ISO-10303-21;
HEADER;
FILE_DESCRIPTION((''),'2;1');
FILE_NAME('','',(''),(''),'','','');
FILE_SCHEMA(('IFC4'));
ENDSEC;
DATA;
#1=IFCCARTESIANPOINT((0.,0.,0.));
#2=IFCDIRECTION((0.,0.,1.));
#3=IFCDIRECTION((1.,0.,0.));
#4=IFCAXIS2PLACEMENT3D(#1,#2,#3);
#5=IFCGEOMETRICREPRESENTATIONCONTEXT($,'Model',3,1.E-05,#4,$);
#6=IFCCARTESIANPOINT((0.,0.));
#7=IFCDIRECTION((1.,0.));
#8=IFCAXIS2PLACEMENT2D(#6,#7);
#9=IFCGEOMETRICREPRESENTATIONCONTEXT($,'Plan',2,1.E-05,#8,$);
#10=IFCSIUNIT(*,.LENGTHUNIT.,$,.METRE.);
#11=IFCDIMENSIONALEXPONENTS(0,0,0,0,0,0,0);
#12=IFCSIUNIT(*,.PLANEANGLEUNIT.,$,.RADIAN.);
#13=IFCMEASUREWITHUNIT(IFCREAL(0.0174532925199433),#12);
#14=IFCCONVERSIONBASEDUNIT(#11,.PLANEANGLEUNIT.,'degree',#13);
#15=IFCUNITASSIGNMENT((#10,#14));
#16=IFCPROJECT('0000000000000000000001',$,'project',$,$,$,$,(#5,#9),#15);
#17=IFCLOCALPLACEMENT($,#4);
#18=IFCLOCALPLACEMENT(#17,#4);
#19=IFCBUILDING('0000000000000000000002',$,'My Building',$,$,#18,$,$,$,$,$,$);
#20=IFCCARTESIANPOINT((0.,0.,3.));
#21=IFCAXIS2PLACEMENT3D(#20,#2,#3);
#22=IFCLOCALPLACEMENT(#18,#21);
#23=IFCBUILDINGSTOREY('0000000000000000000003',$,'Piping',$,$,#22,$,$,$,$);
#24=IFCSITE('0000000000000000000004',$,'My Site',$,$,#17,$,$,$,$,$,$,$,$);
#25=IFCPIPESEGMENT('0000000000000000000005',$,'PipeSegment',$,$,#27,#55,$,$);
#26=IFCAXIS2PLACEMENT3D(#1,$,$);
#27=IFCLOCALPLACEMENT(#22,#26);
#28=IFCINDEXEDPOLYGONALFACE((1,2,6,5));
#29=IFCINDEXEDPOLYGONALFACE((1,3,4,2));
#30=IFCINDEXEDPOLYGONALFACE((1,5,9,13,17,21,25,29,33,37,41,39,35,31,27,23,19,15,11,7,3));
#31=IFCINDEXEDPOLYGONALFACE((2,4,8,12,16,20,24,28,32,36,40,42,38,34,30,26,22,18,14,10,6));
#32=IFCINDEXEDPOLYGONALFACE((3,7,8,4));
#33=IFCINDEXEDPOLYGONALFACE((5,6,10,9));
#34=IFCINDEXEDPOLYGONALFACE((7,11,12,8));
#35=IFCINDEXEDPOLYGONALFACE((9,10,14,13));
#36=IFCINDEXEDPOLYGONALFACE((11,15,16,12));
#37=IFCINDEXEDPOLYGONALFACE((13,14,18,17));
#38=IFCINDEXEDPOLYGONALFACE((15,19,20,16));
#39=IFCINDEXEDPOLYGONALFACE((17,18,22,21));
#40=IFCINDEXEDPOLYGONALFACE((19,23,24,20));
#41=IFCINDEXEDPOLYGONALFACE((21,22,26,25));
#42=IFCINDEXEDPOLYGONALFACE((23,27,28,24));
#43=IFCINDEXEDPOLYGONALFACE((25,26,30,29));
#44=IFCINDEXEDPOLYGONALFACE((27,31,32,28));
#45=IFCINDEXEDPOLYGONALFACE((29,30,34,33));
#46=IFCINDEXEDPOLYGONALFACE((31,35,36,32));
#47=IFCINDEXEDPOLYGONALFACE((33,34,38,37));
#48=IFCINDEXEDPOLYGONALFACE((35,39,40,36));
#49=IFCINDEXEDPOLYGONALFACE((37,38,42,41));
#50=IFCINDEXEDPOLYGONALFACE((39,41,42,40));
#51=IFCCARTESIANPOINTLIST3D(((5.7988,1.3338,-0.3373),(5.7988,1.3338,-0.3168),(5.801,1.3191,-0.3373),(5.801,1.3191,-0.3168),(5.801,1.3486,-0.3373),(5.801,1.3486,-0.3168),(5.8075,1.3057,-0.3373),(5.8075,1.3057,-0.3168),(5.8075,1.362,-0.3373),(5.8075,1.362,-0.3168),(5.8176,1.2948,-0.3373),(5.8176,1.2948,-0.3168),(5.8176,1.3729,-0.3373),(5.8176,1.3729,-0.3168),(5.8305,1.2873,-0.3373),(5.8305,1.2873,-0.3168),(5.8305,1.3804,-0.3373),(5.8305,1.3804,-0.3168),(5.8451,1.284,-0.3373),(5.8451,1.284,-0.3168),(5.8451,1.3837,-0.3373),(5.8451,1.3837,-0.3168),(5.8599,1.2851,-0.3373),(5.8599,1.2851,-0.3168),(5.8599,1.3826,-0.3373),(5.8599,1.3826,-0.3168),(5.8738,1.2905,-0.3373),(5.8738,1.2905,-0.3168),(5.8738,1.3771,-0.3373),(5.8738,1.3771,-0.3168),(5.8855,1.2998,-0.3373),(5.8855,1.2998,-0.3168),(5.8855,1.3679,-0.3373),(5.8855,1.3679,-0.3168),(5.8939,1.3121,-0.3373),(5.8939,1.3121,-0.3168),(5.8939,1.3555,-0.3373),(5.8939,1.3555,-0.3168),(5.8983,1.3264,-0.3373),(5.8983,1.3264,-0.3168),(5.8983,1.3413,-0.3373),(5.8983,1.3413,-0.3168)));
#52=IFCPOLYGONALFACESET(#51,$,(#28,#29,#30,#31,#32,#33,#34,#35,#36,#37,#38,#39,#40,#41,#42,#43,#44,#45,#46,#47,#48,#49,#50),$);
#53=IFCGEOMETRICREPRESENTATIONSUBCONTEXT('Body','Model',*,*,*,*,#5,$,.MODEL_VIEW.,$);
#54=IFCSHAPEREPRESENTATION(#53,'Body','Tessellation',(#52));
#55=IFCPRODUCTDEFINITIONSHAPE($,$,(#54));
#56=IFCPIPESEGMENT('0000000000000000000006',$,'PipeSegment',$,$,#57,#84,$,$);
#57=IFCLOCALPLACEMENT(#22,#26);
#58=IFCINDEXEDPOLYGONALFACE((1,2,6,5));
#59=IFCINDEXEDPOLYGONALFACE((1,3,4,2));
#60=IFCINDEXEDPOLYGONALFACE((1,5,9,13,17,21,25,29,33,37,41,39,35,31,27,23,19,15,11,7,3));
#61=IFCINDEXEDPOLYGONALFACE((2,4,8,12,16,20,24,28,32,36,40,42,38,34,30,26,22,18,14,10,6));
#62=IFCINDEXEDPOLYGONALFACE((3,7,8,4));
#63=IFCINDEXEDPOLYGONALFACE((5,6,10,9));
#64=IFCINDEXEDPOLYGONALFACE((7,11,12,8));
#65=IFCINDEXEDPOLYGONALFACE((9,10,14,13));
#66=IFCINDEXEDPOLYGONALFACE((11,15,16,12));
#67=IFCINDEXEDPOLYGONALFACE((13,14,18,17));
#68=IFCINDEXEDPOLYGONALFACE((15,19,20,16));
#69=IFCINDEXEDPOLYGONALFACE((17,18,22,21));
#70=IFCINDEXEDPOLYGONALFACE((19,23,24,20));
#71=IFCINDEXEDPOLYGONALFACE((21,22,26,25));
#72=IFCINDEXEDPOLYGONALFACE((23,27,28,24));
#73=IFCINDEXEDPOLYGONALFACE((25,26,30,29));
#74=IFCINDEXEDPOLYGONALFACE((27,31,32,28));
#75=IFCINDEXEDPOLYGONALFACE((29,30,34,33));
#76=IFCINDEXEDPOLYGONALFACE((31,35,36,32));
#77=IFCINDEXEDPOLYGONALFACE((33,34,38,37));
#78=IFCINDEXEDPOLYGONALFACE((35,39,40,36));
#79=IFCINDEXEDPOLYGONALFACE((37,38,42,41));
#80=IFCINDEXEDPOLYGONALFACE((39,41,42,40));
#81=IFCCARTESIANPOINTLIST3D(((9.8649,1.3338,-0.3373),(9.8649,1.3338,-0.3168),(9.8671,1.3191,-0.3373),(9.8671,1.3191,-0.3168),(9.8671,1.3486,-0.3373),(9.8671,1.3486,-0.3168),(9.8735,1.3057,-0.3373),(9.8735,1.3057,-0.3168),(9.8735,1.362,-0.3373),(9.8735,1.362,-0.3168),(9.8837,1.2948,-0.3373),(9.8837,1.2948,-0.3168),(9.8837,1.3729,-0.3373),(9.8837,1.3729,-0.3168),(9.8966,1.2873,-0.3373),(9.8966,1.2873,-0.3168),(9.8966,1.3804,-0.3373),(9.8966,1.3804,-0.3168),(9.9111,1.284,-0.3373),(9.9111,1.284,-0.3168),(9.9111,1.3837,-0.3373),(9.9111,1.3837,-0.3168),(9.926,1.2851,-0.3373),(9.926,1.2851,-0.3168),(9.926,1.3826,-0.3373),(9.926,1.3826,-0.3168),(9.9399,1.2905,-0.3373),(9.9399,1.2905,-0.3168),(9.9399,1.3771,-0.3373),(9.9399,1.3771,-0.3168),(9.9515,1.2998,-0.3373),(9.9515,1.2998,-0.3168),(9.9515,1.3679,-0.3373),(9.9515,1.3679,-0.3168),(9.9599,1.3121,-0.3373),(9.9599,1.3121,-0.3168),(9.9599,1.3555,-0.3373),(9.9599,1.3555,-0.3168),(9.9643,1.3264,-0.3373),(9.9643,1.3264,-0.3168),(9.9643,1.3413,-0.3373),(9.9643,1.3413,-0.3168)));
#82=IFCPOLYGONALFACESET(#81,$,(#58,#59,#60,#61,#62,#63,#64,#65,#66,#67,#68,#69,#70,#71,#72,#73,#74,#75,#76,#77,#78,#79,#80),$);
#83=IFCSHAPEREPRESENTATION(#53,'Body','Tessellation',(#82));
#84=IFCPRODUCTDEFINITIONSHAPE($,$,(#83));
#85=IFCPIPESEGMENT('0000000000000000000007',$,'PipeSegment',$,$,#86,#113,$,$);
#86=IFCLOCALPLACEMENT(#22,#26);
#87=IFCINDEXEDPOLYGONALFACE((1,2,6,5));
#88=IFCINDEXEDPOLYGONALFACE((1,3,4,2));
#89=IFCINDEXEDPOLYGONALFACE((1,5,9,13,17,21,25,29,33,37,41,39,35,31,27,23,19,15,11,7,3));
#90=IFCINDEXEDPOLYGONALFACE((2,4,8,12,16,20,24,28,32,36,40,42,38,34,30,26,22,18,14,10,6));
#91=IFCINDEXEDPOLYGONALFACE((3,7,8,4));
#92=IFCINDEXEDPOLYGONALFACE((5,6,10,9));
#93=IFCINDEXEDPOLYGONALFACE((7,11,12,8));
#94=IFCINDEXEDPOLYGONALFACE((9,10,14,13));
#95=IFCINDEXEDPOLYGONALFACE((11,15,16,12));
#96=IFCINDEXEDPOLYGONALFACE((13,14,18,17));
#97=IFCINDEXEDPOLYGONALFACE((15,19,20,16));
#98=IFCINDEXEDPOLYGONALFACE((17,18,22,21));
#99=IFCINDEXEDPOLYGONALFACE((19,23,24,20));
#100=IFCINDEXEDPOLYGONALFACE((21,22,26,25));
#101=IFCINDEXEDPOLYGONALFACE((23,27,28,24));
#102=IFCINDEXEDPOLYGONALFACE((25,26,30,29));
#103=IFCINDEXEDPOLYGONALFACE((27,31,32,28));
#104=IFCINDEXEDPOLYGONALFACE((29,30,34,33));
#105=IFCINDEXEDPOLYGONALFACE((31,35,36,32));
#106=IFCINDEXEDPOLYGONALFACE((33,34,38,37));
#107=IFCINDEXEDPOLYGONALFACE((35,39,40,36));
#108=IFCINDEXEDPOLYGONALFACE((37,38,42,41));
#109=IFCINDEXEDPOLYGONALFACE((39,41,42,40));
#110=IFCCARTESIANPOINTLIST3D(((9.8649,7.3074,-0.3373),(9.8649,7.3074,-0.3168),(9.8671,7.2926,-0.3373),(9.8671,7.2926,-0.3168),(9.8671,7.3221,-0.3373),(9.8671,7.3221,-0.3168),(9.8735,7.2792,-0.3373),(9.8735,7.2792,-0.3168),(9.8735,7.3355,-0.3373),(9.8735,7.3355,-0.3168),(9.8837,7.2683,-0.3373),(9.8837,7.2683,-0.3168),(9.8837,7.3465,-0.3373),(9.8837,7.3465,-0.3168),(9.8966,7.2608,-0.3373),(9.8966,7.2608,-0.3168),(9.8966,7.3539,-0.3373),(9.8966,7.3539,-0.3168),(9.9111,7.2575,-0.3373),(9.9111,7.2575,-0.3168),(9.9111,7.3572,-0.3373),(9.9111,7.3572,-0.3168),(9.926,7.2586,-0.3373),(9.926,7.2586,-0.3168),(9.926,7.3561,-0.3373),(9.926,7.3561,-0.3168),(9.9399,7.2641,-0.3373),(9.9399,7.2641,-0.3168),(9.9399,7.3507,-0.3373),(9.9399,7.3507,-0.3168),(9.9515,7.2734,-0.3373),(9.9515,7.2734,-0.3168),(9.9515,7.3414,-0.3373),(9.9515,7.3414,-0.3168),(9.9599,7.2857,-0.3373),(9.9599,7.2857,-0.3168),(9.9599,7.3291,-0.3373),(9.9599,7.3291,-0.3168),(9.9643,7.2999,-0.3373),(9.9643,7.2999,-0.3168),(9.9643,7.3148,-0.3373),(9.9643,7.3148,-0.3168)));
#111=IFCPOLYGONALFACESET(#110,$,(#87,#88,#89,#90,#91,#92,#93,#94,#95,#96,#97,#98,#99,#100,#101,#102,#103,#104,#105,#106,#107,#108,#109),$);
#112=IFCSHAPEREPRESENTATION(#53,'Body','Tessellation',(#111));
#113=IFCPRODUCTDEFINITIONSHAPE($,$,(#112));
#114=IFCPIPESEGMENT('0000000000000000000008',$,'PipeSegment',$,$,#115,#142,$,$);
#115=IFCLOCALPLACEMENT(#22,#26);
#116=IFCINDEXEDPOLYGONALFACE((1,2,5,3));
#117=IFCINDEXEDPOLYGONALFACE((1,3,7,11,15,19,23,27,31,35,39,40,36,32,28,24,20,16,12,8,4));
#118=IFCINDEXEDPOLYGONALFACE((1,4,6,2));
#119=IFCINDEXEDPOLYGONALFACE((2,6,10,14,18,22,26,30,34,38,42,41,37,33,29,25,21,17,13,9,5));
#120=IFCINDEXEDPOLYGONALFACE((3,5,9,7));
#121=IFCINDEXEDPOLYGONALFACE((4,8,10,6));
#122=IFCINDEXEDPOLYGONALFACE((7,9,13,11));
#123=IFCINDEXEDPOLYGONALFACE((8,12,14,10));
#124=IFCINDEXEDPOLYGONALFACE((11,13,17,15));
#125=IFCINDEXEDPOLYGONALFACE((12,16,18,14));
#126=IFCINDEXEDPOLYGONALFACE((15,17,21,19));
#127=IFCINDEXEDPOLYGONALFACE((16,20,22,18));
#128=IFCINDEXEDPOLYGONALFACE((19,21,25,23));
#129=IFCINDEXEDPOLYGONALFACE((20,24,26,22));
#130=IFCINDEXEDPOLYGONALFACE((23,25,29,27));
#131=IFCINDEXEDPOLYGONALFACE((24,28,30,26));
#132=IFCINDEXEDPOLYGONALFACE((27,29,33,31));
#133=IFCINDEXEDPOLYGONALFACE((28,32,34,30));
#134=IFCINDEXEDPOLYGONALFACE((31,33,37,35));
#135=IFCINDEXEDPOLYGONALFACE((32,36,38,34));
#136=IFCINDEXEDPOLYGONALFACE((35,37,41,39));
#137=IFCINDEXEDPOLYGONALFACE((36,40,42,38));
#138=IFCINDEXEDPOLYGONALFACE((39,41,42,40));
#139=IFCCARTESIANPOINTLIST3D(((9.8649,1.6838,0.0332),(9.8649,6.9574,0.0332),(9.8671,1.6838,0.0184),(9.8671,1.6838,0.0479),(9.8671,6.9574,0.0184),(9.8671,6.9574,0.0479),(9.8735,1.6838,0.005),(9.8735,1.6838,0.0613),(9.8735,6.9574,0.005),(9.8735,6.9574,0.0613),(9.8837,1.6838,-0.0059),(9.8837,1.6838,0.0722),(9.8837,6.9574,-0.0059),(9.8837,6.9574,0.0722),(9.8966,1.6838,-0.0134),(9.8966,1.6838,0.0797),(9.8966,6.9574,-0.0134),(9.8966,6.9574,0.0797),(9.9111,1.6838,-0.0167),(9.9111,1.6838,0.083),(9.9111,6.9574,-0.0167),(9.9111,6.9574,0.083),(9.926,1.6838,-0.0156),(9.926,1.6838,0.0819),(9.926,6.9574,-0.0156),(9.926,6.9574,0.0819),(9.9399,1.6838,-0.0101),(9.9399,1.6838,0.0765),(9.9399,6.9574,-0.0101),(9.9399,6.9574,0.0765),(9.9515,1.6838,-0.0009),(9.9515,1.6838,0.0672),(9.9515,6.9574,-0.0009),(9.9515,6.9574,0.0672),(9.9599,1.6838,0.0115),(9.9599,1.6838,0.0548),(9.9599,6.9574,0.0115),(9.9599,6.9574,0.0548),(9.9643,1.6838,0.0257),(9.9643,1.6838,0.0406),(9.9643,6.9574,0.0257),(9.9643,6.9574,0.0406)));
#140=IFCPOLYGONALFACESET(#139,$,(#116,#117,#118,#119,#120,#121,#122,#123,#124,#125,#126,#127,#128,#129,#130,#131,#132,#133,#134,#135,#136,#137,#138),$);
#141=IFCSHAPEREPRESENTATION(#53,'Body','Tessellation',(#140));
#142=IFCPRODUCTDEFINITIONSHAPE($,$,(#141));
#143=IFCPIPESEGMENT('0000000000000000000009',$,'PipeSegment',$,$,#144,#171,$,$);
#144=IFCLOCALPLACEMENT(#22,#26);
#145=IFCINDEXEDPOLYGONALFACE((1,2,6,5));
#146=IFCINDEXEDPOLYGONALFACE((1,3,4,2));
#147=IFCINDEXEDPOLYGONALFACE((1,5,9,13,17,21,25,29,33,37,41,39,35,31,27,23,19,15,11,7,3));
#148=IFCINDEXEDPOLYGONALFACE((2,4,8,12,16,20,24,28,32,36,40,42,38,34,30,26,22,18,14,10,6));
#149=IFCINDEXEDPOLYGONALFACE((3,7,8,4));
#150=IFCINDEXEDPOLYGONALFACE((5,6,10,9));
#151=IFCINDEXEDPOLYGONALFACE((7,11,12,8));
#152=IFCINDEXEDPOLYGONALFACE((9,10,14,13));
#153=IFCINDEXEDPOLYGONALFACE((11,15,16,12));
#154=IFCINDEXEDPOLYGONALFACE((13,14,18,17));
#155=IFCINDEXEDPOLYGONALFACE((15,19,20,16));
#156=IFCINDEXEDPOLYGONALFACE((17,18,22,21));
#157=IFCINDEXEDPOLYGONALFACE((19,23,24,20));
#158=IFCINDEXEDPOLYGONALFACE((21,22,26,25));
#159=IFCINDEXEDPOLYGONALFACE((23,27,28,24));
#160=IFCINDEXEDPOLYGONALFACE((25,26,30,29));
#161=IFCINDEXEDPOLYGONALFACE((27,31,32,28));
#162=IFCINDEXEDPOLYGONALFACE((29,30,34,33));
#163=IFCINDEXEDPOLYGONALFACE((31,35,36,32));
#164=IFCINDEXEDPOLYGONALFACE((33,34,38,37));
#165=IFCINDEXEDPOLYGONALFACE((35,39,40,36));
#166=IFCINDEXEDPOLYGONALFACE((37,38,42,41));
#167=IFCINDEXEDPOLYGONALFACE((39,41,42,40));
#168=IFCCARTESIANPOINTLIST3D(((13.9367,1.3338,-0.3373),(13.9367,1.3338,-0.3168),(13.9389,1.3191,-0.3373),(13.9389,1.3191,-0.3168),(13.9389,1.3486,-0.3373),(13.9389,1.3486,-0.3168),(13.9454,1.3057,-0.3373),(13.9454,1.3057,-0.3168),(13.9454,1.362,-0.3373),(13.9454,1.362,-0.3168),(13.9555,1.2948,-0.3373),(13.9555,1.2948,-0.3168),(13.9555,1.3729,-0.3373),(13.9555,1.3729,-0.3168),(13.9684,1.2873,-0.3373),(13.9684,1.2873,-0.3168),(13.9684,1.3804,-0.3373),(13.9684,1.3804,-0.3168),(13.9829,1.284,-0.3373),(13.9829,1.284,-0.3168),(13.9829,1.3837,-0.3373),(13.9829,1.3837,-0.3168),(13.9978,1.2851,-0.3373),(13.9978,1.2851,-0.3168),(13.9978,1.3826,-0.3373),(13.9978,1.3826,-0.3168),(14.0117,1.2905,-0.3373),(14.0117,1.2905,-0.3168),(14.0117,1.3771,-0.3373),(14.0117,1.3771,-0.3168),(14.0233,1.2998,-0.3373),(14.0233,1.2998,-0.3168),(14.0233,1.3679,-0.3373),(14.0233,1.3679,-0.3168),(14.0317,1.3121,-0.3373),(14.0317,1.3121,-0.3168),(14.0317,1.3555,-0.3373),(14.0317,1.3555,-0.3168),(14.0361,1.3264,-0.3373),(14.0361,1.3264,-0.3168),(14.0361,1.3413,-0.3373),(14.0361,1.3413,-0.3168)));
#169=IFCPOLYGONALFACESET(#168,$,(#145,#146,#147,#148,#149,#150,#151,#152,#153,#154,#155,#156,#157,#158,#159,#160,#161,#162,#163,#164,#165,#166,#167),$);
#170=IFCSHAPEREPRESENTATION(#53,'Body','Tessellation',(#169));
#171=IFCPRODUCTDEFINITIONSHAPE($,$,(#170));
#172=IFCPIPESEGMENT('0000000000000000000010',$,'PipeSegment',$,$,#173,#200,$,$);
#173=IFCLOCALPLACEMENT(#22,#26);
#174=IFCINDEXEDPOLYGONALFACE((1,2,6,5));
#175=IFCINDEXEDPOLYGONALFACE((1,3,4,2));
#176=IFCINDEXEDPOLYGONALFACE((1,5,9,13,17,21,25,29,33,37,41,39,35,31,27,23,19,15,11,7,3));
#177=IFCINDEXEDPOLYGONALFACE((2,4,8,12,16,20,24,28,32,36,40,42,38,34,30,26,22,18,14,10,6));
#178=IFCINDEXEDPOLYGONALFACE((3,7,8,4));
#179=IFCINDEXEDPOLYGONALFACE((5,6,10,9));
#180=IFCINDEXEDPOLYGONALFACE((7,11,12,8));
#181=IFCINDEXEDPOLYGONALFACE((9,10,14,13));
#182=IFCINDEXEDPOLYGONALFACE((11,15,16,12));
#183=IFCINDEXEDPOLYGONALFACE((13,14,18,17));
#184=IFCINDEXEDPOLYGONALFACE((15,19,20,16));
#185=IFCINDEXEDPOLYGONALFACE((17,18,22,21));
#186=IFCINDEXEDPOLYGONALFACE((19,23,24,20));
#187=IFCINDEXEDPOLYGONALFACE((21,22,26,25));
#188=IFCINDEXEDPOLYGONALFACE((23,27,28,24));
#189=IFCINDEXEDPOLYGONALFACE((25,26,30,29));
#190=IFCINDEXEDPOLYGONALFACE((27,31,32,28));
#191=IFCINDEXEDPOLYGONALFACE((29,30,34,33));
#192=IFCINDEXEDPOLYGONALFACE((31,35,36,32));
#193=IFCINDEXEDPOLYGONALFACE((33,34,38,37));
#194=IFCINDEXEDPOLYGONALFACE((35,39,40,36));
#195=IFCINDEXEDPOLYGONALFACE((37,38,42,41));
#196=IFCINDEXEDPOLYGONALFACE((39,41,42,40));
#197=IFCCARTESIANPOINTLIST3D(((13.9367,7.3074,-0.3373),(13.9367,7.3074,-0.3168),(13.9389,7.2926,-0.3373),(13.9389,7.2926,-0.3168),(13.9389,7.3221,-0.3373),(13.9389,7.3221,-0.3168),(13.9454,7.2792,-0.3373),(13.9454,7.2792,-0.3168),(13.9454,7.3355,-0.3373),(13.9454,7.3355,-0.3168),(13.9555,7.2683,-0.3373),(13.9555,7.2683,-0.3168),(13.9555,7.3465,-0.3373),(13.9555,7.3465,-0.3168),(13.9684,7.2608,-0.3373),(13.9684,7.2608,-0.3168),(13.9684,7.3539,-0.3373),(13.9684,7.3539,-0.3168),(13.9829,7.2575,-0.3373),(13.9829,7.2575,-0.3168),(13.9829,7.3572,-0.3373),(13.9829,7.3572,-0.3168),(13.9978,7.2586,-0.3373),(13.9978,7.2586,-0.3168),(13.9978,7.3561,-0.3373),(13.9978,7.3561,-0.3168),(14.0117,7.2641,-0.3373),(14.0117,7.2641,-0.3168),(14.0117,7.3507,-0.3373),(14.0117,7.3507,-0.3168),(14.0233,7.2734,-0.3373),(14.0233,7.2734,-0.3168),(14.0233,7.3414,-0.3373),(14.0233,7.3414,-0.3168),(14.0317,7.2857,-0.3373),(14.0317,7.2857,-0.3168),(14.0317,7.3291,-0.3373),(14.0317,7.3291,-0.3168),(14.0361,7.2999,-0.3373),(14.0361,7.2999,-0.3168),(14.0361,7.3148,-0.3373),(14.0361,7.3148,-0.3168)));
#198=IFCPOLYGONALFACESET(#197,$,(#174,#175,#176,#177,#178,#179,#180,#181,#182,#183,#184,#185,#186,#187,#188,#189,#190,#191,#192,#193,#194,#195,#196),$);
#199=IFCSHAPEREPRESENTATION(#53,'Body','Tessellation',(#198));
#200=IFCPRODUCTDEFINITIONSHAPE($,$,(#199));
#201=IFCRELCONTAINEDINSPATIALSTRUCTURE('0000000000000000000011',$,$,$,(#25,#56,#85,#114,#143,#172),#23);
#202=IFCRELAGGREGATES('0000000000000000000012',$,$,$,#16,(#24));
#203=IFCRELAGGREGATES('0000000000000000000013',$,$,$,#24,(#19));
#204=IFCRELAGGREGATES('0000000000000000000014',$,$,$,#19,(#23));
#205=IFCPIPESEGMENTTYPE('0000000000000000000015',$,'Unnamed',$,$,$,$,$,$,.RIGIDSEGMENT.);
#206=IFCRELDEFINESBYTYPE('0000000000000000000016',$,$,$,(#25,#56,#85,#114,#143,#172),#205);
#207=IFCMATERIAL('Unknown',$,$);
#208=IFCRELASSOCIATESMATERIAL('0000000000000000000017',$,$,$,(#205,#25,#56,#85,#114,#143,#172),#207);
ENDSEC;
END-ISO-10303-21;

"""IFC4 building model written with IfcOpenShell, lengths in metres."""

from ifc_helpers import new_model, entity, si_unit, converted_unit, frame, origin_with_axes, origin_2d_with_axis, place, context, subcontext, project, spatial, circle, extrude, material, material_profile, profile_set, profile_usage, type_object, element, save


model = new_model("IFC4")

# Units and contexts
model_context = context("Model", 3, precision=1e-05, world=origin_with_axes())
plan_context = context("Plan", 2, precision=1e-05, world=origin_2d_with_axis())
body_context = subcontext(model_context, "Body", "Model", "MODEL_VIEW")
ifc_project = project(units=[si_unit("LENGTHUNIT", "METRE"), converted_unit("PLANEANGLEUNIT", "degree", entity("IfcReal", 0.0174532925199433), si_unit("PLANEANGLEUNIT", "RADIAN"), dimensions=[0, 0, 0, 0, 0, 0, 0])], contexts=[model_context, plan_context])

# Site, building, storey
site_placement = place(None, origin_with_axes())
site = spatial("IfcSite", under=ifc_project, at=site_placement, Name="My Site")
building_placement = place(site_placement, origin_with_axes())
building = spatial("IfcBuilding", under=site, at=building_placement, Name="My Building")
storey_placement = place(building_placement, frame((0.0, 0.0, 3.0), z_axis=(0.0, 0.0, 1.0), x_axis=(1.0, 0.0, 0.0)))
storey = spatial("IfcBuildingStorey", under=building, at=storey_placement, Name="Piping")

# Pipe segments
ifc_material = material(Name="Unknown")
ifc_material_profile = material_profile(ifc_material, circle(Radius=0.05))
ifc_profile_set = profile_set([ifc_material_profile])
pipe_segment_type = type_object("IfcPipeSegmentType", Name="Unnamed", PredefinedType="RIGIDSEGMENT", material=ifc_profile_set)
ifc_profile_usage_1 = profile_usage(ifc_profile_set, cardinal=5)
pipe_segment_1_placement = place(storey_placement, frame((5.8488, 1.3338, -0.3168), z_axis=(0.0, 0.0, -1.0), x_axis=(-1.0, 0.0, 0.0)))
element("IfcPipeSegment", 1, at=pipe_segment_1_placement, inside=storey, type_object=pipe_segment_type, material=ifc_profile_usage_1, Name="PipeSegment", context=body_context, shape_type="SweptSolid", body=[
    extrude(circle(Radius=0.05), origin_with_axes(), (0.0, 0.0, 1.0), 0.0204),
])
ifc_profile_usage_2 = profile_usage(ifc_profile_set, cardinal=5)
pipe_segment_2_placement = place(storey_placement, frame((9.9149, 1.3338, -0.3168), z_axis=(0.0, 0.0, -1.0), x_axis=(-1.0, 0.0, 0.0)))
element("IfcPipeSegment", 2, at=pipe_segment_2_placement, inside=storey, type_object=pipe_segment_type, material=ifc_profile_usage_2, Name="PipeSegment", context=body_context, shape_type="SweptSolid", body=[
    extrude(circle(Radius=0.05), origin_with_axes(), (0.0, 0.0, 1.0), 0.0204),
])
ifc_profile_usage_3 = profile_usage(ifc_profile_set, cardinal=5)
pipe_segment_3_placement = place(storey_placement, frame((9.9149, 7.3074, -0.3168), z_axis=(0.0, 0.0, -1.0), x_axis=(-1.0, 0.0, 0.0)))
element("IfcPipeSegment", 3, at=pipe_segment_3_placement, inside=storey, type_object=pipe_segment_type, material=ifc_profile_usage_3, Name="PipeSegment", context=body_context, shape_type="SweptSolid", body=[
    extrude(circle(Radius=0.05), origin_with_axes(), (0.0, 0.0, 1.0), 0.0204),
])
ifc_profile_usage_4 = profile_usage(ifc_profile_set, cardinal=5)
pipe_segment_4_placement = place(storey_placement, frame((9.9149, 1.6838, 0.0332), z_axis=(0.0, 1.0, 0.0), x_axis=(-1.0, 0.0, 0.0)))
element("IfcPipeSegment", 4, at=pipe_segment_4_placement, inside=storey, type_object=pipe_segment_type, material=ifc_profile_usage_4, Name="PipeSegment", context=body_context, shape_type="SweptSolid", body=[
    extrude(circle(Radius=0.05), origin_with_axes(), (0.0, 0.0, 1.0), 5.2735),
])
ifc_profile_usage_5 = profile_usage(ifc_profile_set, cardinal=5)
pipe_segment_5_placement = place(storey_placement, frame((13.9867, 1.3338, -0.3168), z_axis=(0.0, 0.0, -1.0), x_axis=(-1.0, 0.0, 0.0)))
element("IfcPipeSegment", 5, at=pipe_segment_5_placement, inside=storey, type_object=pipe_segment_type, material=ifc_profile_usage_5, Name="PipeSegment", context=body_context, shape_type="SweptSolid", body=[
    extrude(circle(Radius=0.05), origin_with_axes(), (0.0, 0.0, 1.0), 0.0204),
])
ifc_profile_usage_6 = profile_usage(ifc_profile_set, cardinal=5)
pipe_segment_6_placement = place(storey_placement, frame((13.9867, 7.3074, -0.3168), z_axis=(0.0, 0.0, -1.0), x_axis=(-1.0, 0.0, 0.0)))
element("IfcPipeSegment", 6, at=pipe_segment_6_placement, inside=storey, type_object=pipe_segment_type, material=ifc_profile_usage_6, Name="PipeSegment", context=body_context, shape_type="SweptSolid", body=[
    extrude(circle(Radius=0.05), origin_with_axes(), (0.0, 0.0, 1.0), 0.0204),
])

save(model, "model.ifc")
